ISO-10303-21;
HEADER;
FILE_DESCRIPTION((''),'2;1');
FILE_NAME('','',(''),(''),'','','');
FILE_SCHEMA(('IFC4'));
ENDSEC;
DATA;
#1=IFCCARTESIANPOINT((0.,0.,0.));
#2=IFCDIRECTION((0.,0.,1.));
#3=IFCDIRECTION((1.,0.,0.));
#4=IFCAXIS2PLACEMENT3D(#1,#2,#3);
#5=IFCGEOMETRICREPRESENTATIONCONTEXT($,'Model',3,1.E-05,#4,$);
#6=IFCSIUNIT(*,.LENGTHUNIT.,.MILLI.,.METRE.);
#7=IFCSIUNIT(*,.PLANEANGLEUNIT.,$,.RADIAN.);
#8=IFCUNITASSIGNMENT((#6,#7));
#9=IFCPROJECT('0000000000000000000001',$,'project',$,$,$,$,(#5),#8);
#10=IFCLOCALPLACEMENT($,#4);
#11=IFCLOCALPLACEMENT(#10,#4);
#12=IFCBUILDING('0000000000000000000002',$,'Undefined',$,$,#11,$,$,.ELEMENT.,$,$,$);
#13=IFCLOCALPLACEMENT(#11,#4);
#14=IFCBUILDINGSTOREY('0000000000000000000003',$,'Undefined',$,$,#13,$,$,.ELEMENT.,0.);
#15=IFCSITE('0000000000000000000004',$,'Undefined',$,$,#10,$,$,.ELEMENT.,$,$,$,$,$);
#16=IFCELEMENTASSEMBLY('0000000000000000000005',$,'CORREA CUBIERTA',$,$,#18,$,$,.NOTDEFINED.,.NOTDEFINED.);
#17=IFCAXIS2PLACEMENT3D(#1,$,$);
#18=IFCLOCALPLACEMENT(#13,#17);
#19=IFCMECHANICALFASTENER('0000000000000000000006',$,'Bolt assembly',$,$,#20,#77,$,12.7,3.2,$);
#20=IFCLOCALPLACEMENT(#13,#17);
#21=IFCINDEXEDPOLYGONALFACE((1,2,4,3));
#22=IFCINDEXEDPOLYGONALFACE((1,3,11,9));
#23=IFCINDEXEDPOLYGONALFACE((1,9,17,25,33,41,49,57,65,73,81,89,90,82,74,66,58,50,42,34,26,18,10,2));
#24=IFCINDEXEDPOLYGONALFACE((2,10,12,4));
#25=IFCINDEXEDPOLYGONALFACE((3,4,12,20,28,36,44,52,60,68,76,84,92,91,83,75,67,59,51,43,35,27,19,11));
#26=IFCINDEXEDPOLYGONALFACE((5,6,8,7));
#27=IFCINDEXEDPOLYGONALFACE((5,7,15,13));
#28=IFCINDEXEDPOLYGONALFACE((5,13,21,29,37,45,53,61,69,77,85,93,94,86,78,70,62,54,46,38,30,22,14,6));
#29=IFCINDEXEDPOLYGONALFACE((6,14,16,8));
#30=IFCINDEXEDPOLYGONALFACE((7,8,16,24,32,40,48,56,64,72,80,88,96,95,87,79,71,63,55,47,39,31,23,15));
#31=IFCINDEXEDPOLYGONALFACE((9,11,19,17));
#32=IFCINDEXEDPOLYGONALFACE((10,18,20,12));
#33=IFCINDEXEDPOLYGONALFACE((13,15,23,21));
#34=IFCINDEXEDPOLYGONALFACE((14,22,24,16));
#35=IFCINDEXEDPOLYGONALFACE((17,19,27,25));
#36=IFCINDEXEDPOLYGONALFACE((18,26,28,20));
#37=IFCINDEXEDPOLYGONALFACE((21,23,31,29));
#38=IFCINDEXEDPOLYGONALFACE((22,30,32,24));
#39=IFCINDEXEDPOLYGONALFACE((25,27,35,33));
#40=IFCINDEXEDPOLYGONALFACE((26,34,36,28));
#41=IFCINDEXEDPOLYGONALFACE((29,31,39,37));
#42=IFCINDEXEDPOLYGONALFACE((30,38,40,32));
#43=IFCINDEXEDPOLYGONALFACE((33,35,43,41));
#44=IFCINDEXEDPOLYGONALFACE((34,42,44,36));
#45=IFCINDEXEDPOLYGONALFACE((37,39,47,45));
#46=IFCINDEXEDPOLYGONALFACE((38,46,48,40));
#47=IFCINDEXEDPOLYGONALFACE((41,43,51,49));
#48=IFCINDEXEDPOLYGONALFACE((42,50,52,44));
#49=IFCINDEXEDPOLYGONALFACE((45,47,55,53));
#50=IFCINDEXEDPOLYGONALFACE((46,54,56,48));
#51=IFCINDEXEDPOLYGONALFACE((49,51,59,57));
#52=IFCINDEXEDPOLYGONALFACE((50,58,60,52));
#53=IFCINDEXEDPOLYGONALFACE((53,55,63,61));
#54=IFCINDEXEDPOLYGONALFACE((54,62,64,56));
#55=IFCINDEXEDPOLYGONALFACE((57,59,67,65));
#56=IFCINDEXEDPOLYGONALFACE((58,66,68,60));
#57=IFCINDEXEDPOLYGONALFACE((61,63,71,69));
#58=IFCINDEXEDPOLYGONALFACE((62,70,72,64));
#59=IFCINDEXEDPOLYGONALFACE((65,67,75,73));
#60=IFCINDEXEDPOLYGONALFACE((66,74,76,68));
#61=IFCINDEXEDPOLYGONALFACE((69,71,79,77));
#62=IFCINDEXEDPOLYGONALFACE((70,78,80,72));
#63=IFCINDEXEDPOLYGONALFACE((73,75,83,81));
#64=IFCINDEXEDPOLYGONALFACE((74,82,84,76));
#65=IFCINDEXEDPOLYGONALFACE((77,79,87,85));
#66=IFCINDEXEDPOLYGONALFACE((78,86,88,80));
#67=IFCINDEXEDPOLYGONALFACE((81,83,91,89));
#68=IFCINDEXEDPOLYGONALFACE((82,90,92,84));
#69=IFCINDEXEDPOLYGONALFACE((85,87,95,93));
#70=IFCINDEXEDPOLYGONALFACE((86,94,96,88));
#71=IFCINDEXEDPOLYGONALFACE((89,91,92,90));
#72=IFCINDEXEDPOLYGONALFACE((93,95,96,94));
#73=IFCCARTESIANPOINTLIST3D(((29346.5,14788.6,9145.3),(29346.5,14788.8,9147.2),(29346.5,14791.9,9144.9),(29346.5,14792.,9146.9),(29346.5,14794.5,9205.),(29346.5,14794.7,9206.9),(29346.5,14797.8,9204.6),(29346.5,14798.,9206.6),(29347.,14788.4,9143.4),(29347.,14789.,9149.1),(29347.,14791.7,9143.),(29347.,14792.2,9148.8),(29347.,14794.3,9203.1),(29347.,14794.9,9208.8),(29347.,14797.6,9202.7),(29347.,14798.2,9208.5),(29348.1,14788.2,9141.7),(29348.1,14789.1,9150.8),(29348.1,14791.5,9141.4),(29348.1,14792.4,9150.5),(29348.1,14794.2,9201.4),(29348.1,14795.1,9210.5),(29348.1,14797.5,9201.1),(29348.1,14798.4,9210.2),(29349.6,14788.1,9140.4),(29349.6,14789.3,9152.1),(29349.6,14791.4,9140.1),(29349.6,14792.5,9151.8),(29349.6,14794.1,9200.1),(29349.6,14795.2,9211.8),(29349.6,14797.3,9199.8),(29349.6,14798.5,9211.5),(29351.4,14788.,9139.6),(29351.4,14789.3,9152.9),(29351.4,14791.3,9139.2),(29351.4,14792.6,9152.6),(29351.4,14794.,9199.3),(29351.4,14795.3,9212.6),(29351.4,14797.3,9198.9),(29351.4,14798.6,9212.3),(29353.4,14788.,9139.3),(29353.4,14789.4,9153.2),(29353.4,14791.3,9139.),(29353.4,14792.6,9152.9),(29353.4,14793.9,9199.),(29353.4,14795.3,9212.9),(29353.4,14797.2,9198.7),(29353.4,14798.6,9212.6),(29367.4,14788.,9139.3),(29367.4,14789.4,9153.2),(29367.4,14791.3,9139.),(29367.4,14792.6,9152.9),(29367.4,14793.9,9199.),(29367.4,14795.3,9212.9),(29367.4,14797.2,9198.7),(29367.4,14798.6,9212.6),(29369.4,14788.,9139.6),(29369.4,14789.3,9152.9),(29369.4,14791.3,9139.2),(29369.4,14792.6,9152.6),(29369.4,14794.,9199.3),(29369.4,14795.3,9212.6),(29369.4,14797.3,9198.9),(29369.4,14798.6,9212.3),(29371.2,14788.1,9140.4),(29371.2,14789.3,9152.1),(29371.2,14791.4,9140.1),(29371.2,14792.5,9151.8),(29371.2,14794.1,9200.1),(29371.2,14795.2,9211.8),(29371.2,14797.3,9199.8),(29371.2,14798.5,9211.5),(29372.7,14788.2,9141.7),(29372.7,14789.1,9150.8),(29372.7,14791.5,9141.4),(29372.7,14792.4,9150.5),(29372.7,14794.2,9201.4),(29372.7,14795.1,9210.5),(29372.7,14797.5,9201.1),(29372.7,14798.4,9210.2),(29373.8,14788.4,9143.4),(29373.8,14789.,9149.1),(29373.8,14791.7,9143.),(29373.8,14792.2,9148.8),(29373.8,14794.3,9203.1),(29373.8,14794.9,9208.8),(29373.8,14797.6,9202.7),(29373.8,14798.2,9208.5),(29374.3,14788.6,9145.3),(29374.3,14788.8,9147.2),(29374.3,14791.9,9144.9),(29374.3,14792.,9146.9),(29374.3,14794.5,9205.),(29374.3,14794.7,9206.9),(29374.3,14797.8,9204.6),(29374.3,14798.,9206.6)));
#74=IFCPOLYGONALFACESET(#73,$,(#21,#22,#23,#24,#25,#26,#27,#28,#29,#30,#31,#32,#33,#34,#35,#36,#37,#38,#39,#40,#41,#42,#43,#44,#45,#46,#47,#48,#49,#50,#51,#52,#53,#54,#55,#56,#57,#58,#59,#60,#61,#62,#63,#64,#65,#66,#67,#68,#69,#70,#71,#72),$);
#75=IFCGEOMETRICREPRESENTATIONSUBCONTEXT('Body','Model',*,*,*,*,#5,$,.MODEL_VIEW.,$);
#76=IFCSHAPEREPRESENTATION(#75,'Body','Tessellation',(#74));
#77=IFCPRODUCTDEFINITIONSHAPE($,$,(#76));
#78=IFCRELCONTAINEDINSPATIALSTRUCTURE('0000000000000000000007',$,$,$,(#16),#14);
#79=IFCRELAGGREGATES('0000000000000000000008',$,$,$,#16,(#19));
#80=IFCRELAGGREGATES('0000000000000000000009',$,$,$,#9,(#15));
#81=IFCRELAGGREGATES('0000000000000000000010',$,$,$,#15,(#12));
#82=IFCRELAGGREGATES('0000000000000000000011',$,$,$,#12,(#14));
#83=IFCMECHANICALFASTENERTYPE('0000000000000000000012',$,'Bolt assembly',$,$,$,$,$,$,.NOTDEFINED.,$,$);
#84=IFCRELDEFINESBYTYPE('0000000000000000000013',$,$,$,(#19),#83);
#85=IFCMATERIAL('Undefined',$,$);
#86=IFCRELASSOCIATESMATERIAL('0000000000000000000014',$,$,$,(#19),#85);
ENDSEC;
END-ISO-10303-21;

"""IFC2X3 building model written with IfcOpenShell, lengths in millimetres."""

from ifc_helpers import new_model, si_unit, frame, frame_2d, origin_with_axes, place, context, subcontext, project, spatial, polyline, circle_curve, parameter, trimmed, segment, composite_curve, outline, extrude, source, transform, mapped, material, type_object, element, aggregate, save


model = new_model("IFC2X3")

# Units and contexts
model_context = context("Model", 3, precision=1e-05, world=origin_with_axes())
body_context = subcontext(model_context, "Body", "Model", "MODEL_VIEW")
ifc_project = project(units=[si_unit("LENGTHUNIT", "METRE", prefix="MILLI"), si_unit("PLANEANGLEUNIT", "RADIAN")], contexts=[model_context])

# Site, building, storey
site_placement = place(None, origin_with_axes())
site = spatial("IfcSite", under=ifc_project, at=site_placement, Name="Undefined", CompositionType="ELEMENT")
building_placement = place(site_placement, origin_with_axes())
building = spatial("IfcBuilding", under=site, at=building_placement, Name="Undefined", CompositionType="ELEMENT")
storey_placement = place(building_placement, origin_with_axes())
storey = spatial("IfcBuildingStorey", under=building, at=storey_placement, Name="Undefined", CompositionType="ELEMENT", Elevation=0.0)

# Element assembly, mechanical fastener
ifc_material_1 = material(Name="Undefined")
mechanical_fastener_type = type_object("IfcMechanicalFastenerType", Name="Bolt assembly")
assembly_1_placement = place(storey_placement, origin_with_axes())
assembly_1 = element("IfcElementAssembly", 1, at=assembly_1_placement, inside=storey, Name="CORREA CUBIERTA", AssemblyPlace="NOTDEFINED", PredefinedType="NOTDEFINED")
shared_shape_1 = source(origin_with_axes(), body_context, "Body", "SweptSolid", [
    extrude(outline(composite_curve([segment(polyline([(7.0, 7.0), (7.0, -7.0)]), True, "CONTINUOUS"), segment(trimmed(circle_curve(frame_2d((0.0, -7.0), x_axis=(1.0, 0.0)), 7.0), [parameter(0.0)], [parameter(3.141593)], False, "PARAMETER"), True, "CONTINUOUS"), segment(polyline([(-7.0, -7.0), (-7.0, 7.0)]), True, "CONTINUOUS"), segment(trimmed(circle_curve(frame_2d((0.0, 7.0), x_axis=(-1.0, 0.0)), 7.0), [parameter(0.0)], [parameter(3.141593)], False, "PARAMETER"), True, "DISCONTINUOUS")], self_intersect=False)), frame((0.0, 0.0, 0.0), z_axis=(0.0, 1.0, 0.0), x_axis=(1.0, 0.0, 0.0)), (0.0, 0.0, 1.0), 3.3),
])
mechanical_fastener_1_placement = place(assembly_1_placement, frame((29360.4, 14794.6, 9205.9), z_axis=(1.0, 0.0, 0.0), x_axis=(0.0, -0.099503, -0.995037)))
mechanical_fastener_1 = element("IfcMechanicalFastener", 2, at=mechanical_fastener_1_placement, type_object=mechanical_fastener_type, material=ifc_material_1, Name="Bolt assembly", NominalDiameter=12.7, NominalLength=3.2, context=body_context, shape_type="MappedRepresentation", body=[
    mapped(shared_shape_1, transform((0.0, 0.0, 0.0))),
    mapped(shared_shape_1, transform((60.0, 0.0, 0.0))),
])

aggregate(assembly_1, [mechanical_fastener_1])

save(model, "model.ifc")
